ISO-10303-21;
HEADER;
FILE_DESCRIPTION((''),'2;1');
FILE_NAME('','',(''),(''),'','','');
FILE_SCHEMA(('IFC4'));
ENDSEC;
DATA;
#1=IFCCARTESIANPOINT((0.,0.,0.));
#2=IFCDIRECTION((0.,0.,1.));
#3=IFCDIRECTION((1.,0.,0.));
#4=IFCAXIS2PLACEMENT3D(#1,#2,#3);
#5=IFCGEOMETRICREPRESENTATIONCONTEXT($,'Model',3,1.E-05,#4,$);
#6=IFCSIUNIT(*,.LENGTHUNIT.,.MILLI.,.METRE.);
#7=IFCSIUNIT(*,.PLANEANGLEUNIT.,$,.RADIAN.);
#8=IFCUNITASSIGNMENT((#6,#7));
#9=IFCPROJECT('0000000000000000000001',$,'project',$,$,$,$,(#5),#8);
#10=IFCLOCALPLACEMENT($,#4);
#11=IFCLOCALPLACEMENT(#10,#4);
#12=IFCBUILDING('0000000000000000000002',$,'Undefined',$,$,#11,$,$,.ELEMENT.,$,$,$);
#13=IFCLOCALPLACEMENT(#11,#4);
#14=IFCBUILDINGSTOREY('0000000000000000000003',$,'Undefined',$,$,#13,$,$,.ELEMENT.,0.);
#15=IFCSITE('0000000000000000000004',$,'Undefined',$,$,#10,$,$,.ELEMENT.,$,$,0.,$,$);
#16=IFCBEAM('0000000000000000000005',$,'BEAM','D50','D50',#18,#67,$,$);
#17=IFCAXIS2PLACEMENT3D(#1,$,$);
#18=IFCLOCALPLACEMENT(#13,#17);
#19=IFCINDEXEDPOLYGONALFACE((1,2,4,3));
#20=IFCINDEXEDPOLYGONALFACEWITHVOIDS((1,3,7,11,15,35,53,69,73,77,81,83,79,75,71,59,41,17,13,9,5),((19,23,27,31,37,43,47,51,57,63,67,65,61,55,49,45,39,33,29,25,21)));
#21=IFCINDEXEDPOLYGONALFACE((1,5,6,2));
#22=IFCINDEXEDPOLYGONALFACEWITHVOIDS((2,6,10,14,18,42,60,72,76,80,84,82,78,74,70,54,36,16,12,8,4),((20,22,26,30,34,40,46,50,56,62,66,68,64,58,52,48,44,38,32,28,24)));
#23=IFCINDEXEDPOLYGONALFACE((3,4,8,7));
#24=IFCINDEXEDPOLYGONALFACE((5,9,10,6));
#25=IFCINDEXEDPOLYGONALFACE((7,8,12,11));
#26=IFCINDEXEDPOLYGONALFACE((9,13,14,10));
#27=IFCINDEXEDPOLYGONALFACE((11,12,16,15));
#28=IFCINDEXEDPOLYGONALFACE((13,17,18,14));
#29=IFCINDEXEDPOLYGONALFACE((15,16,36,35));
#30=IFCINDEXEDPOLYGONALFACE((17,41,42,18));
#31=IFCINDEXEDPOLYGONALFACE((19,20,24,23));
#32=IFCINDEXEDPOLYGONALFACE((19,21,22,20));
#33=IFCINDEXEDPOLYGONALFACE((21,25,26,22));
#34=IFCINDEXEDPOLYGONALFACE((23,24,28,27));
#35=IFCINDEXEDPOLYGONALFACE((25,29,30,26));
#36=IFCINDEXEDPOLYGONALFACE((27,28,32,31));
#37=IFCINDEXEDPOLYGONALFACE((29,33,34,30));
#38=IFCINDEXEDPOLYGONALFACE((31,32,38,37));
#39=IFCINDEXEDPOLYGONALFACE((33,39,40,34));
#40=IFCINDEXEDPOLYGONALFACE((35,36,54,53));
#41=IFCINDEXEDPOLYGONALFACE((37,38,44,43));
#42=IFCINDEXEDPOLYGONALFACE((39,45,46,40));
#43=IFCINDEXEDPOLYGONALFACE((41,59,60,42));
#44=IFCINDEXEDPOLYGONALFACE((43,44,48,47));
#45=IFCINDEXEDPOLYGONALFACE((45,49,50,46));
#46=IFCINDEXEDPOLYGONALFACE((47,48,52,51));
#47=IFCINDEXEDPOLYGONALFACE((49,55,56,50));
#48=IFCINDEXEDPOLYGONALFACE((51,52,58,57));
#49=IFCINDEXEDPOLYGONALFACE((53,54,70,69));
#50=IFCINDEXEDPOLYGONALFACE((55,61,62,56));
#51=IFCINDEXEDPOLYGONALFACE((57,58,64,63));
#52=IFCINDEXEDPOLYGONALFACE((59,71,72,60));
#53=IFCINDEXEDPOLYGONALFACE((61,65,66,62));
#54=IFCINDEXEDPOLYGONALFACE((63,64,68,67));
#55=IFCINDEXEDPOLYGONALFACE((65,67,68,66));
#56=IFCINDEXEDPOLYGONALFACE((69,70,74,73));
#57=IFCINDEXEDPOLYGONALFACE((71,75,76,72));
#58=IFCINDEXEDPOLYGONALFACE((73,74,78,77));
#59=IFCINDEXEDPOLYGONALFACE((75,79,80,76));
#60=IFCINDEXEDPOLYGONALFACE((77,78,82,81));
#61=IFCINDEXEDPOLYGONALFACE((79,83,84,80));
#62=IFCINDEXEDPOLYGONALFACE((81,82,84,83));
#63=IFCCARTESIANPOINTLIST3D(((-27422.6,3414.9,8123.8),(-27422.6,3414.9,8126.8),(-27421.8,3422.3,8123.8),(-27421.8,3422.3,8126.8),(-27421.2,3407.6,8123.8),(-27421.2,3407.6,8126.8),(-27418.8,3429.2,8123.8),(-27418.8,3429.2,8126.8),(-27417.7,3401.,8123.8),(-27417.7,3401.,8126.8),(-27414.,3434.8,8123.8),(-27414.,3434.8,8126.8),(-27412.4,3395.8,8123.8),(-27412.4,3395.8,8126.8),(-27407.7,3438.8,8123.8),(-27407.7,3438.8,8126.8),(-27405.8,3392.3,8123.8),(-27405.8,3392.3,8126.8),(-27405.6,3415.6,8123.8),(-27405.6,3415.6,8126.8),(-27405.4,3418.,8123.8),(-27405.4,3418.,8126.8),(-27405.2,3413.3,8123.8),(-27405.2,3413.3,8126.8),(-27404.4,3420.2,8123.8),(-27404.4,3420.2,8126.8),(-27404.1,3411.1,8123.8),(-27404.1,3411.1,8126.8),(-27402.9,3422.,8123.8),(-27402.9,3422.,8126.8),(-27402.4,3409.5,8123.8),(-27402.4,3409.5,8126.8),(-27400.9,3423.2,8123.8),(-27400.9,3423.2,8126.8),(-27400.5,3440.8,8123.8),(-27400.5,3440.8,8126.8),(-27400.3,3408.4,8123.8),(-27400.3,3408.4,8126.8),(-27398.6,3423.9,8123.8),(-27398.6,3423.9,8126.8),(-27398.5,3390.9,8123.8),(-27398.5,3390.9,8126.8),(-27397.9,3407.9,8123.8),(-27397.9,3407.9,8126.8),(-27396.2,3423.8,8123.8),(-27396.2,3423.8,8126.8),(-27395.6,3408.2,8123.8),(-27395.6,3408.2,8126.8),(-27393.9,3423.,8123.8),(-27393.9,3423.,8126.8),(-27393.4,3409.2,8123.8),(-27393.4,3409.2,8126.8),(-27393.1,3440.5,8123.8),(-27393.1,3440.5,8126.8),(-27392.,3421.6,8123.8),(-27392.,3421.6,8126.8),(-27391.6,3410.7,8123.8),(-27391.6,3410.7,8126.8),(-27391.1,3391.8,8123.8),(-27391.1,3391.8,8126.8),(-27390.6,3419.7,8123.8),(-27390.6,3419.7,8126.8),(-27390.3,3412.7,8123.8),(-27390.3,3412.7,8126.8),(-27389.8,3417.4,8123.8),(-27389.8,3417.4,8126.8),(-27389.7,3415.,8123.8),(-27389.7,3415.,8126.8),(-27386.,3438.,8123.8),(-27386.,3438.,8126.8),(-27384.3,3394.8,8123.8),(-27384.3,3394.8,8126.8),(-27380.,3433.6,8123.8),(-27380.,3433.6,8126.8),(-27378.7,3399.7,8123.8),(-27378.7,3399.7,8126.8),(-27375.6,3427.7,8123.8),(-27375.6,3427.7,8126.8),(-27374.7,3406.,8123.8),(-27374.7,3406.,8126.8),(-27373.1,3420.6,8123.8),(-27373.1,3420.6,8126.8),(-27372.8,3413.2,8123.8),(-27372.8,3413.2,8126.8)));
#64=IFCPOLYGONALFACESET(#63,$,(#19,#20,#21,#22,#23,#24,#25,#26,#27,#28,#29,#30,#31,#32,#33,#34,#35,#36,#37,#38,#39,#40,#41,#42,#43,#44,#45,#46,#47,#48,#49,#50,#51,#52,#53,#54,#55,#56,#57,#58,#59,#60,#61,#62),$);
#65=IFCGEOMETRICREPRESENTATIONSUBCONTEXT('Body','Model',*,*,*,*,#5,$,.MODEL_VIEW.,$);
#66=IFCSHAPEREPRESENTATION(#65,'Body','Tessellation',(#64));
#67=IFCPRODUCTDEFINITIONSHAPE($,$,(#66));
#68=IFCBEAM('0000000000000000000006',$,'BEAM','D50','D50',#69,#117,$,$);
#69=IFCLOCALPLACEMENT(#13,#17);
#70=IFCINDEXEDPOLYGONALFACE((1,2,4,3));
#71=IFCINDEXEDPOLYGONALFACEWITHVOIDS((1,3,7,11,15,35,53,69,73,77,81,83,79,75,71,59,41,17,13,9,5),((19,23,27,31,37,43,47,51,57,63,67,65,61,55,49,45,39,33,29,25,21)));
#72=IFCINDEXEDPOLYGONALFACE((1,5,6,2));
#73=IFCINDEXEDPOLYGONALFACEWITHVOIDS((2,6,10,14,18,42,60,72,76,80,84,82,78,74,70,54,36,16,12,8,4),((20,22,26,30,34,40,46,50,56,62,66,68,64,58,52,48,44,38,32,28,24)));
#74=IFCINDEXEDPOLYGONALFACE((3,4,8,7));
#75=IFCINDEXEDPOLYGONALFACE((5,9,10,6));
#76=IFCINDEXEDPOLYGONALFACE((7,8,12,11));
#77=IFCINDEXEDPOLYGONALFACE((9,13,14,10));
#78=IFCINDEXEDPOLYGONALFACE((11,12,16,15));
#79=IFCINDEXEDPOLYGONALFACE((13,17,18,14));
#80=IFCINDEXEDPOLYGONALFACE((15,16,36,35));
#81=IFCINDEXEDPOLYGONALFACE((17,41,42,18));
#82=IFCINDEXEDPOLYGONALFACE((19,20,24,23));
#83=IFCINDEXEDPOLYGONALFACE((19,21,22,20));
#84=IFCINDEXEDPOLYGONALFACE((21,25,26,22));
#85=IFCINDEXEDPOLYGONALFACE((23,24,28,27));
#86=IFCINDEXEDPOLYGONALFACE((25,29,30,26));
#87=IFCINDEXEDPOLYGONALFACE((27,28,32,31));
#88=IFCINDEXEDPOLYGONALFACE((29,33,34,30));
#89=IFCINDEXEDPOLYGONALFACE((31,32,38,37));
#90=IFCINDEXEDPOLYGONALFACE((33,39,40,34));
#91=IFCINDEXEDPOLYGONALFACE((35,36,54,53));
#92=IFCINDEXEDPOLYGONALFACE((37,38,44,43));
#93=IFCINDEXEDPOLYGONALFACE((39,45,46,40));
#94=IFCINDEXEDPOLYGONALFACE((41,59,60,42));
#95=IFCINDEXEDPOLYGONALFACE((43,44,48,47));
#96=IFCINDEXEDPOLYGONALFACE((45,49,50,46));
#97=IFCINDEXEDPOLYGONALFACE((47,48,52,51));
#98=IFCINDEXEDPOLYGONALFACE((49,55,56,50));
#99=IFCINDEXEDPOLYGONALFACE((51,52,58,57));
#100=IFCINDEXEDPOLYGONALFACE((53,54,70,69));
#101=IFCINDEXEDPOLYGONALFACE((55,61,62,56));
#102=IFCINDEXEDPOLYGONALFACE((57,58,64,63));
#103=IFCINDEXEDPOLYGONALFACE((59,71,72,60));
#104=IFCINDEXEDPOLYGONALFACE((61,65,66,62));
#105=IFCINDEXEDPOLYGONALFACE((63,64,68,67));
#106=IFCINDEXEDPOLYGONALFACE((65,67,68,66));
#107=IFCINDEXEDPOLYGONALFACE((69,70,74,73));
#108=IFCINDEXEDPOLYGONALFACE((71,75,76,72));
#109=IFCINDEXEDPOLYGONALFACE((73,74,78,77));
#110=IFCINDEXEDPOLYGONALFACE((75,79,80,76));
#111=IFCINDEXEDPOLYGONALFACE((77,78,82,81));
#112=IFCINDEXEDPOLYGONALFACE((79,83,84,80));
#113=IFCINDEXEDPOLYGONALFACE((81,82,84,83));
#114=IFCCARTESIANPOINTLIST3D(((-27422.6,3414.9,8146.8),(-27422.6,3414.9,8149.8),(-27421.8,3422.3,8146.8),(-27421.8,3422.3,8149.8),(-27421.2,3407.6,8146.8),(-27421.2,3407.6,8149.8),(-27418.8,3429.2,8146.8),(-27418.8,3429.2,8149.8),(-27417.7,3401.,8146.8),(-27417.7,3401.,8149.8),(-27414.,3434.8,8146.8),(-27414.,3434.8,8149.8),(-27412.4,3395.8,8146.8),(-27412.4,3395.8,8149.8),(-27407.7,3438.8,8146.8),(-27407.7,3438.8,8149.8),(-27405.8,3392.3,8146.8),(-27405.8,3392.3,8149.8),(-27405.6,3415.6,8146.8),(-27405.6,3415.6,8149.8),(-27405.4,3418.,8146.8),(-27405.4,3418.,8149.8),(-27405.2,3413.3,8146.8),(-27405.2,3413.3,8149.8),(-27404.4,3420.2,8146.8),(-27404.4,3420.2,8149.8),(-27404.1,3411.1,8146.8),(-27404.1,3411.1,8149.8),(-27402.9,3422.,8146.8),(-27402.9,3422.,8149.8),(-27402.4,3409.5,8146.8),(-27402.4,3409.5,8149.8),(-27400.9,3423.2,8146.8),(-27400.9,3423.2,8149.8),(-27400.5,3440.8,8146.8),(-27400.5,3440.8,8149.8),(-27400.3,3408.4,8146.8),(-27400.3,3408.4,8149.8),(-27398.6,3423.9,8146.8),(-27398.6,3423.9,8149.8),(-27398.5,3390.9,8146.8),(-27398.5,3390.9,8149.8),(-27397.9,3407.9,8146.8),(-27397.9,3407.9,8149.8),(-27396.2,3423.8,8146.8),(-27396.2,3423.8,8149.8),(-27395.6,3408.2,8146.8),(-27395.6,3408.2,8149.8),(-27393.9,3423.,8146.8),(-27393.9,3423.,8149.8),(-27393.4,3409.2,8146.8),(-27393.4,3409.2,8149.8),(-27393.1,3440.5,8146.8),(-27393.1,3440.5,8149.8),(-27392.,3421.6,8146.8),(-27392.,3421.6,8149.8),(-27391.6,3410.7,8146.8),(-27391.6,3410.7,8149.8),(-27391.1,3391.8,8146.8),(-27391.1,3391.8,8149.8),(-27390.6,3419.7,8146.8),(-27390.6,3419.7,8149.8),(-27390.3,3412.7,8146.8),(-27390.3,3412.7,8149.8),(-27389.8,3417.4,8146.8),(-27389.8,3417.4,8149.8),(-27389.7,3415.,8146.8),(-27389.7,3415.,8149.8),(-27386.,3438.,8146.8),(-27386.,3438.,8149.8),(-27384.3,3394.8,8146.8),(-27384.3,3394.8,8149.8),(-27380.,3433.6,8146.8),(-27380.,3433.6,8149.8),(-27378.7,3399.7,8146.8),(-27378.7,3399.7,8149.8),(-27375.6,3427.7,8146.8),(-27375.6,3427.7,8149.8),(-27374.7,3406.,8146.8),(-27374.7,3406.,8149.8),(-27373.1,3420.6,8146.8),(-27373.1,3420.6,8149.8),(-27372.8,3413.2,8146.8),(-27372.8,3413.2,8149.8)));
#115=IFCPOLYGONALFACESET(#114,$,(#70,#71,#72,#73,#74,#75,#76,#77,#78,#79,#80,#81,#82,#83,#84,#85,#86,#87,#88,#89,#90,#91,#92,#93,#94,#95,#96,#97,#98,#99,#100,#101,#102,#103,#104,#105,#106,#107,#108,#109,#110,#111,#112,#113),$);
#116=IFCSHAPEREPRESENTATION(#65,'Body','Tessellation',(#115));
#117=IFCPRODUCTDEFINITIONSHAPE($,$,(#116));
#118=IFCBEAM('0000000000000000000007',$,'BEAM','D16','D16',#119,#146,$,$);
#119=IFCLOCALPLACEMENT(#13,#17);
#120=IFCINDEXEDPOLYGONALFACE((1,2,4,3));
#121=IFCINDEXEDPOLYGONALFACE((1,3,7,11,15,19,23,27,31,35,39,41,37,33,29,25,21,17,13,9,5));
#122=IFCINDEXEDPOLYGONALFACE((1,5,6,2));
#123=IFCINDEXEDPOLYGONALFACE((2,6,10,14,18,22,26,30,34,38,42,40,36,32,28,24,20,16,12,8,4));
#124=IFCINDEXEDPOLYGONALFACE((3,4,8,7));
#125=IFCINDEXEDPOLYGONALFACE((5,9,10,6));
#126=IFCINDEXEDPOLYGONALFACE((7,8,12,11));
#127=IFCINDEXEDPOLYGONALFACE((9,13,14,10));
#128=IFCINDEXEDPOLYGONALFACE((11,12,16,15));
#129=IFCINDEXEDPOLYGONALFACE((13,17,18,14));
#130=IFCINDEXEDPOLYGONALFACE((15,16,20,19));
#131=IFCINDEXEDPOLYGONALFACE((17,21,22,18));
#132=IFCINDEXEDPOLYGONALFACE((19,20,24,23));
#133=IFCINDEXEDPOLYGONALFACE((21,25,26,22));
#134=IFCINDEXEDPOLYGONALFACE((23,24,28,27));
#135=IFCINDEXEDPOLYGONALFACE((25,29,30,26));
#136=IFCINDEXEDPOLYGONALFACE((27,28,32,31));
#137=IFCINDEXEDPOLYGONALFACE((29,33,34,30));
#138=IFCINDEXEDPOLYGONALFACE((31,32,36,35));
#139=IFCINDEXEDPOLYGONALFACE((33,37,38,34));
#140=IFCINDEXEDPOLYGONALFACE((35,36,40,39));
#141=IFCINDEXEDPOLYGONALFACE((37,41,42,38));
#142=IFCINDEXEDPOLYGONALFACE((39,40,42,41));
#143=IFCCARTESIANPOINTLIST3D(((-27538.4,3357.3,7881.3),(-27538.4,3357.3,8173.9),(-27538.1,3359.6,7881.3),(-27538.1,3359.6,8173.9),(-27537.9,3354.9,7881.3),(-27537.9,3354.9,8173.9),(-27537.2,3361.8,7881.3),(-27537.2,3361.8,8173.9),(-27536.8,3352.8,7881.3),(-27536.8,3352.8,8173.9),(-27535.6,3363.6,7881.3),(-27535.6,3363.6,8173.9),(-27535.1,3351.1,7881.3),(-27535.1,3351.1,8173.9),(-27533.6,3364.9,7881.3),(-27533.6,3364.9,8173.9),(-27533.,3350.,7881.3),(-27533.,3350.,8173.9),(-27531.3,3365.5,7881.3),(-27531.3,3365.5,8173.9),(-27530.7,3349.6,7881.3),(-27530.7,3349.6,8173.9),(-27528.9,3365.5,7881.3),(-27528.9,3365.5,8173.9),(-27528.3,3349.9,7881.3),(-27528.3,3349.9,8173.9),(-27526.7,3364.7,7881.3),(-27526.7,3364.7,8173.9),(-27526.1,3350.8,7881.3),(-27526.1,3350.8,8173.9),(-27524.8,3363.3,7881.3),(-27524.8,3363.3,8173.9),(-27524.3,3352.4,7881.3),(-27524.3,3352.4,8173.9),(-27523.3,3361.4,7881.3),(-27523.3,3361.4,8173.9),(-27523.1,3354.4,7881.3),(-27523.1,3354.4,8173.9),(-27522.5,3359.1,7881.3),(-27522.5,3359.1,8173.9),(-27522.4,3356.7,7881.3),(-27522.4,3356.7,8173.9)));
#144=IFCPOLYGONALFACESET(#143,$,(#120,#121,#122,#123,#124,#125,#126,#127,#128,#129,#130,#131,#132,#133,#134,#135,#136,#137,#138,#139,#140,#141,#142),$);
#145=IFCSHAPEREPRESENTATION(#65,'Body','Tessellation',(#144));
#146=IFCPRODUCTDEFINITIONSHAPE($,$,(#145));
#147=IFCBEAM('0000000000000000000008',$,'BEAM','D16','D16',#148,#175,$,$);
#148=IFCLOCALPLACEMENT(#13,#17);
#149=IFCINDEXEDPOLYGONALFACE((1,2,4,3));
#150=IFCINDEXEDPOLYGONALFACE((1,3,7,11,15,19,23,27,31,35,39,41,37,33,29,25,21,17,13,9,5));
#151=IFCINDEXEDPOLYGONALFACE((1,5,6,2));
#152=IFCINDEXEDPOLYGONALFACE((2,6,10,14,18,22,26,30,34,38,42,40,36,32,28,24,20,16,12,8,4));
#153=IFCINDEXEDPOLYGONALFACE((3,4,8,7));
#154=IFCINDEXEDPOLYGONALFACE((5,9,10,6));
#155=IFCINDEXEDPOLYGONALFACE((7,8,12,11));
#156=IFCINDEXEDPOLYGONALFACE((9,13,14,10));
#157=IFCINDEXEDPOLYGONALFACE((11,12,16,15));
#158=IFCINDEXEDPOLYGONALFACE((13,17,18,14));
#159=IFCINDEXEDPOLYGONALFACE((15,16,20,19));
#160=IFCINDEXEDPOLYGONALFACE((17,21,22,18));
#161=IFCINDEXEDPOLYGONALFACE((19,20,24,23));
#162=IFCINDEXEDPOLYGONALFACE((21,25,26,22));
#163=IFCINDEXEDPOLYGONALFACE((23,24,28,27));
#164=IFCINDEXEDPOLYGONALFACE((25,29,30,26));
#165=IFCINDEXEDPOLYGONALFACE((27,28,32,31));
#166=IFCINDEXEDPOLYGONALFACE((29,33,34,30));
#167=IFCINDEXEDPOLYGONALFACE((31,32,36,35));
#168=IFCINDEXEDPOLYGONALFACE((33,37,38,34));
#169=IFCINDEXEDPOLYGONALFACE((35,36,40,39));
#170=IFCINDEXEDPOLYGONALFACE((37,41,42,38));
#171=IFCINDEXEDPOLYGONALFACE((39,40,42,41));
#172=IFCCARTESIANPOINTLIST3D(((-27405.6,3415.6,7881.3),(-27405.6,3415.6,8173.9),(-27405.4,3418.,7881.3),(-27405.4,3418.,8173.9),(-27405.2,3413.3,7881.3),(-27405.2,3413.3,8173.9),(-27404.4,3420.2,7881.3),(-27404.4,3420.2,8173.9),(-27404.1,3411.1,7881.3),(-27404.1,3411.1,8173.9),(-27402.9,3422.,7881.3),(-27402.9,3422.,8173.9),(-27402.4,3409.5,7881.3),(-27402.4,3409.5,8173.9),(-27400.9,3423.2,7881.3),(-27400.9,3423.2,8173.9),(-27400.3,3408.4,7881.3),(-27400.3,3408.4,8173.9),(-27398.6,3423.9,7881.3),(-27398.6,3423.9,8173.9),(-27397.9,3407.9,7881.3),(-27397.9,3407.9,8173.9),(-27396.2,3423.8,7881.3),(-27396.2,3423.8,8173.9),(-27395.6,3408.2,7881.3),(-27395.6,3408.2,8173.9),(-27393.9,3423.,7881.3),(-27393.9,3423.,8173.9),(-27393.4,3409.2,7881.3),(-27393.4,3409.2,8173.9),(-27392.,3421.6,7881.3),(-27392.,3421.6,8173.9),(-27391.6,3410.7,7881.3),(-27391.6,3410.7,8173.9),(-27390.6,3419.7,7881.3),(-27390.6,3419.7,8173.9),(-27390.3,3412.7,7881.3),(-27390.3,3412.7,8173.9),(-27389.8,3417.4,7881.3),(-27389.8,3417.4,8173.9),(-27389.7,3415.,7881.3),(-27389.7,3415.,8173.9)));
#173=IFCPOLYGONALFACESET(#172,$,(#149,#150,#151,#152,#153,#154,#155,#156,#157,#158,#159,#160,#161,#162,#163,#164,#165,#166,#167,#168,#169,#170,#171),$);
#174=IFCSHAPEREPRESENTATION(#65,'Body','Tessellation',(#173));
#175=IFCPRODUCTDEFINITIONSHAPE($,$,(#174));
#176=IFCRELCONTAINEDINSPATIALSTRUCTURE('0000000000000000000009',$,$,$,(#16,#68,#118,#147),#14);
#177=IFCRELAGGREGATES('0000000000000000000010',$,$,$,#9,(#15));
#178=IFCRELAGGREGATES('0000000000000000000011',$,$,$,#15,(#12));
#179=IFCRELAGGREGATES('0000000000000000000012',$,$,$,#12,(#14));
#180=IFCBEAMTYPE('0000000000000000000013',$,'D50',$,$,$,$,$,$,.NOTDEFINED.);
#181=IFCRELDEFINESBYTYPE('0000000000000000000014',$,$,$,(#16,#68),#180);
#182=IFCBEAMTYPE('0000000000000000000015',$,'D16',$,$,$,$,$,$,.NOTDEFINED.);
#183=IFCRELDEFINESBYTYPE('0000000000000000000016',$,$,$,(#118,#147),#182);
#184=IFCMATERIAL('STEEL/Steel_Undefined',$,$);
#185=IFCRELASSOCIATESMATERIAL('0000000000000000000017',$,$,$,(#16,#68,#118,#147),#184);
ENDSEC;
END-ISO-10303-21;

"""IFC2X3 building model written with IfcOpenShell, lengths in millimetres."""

from ifc_helpers import new_model, si_unit, frame, origin_with_axes, origin_2d_with_axis, place, context, subcontext, project, spatial, circle, extrude, material, type_object, element, save


model = new_model("IFC2X3")

# Units and contexts
model_context = context("Model", 3, precision=1e-05, world=origin_with_axes())
body_context = subcontext(model_context, "Body", "Model", "MODEL_VIEW")
ifc_project = project(units=[si_unit("LENGTHUNIT", "METRE", prefix="MILLI"), si_unit("PLANEANGLEUNIT", "RADIAN")], contexts=[model_context])

# Site, building, storey
site_placement = place(None, origin_with_axes())
site = spatial("IfcSite", under=ifc_project, at=site_placement, Name="Undefined", CompositionType="ELEMENT", RefElevation=0.0)
building_placement = place(site_placement, origin_with_axes())
building = spatial("IfcBuilding", under=site, at=building_placement, Name="Undefined", CompositionType="ELEMENT")
storey_placement = place(building_placement, origin_with_axes())
storey = spatial("IfcBuildingStorey", under=building, at=storey_placement, Name="Undefined", CompositionType="ELEMENT", Elevation=0.0)

# Shared definitions
ifc_material = material(Name="STEEL/Steel_Undefined")

# Beams, openings
beam_type_1 = type_object("IfcBeamType", Name="D50", PredefinedType="NOTDEFINED")
beam_1_placement = place(storey_placement, frame((-27397.6, 3415.9, 8126.8), z_axis=(-0.915553, -0.402198, 0.0), x_axis=(0.0, 0.0, -1.0)))
beam_1 = element("IfcBeam", 1, at=beam_1_placement, inside=storey, type_object=beam_type_1, material=ifc_material, Name="BEAM", Description="D50", ObjectType="D50", context=body_context, shape_type="SweptSolid", body=[
    extrude(circle(Radius=25.0, at=origin_2d_with_axis()), frame((3.0, 0.0, 0.0), z_axis=(-1.0, 0.0, 0.0), x_axis=(0.0, -1.0, 0.0)), (0.0, 0.0, 1.0), 3.0),
])
opening_1_placement = place(storey_placement, frame((-27397.6, 3415.9, 8126.8), z_axis=(-0.915553, -0.402198, 0.0), x_axis=(0.0, 0.0, -1.0)))
element("IfcOpeningElement", 2, at=opening_1_placement, cuts=beam_1, ObjectType="Recess", context=body_context, shape_type="SweptSolid", body=[
    extrude(circle(Radius=8.0, at=origin_2d_with_axis()), frame((245.5, 0.0, 0.0), z_axis=(-1.0, 0.0, 0.0), x_axis=(0.0, -1.0, 0.0)), (0.0, 0.0, 1.0), 292.6),
])
beam_2_placement = place(storey_placement, frame((-27397.6, 3415.9, 8149.8), z_axis=(-0.915553, -0.402198, 0.0), x_axis=(0.0, 0.0, -1.0)))
beam_2 = element("IfcBeam", 3, at=beam_2_placement, inside=storey, type_object=beam_type_1, material=ifc_material, Name="BEAM", Description="D50", ObjectType="D50", context=body_context, shape_type="SweptSolid", body=[
    extrude(circle(Radius=25.0, at=origin_2d_with_axis()), frame((3.0, 0.0, 0.0), z_axis=(-1.0, 0.0, 0.0), x_axis=(0.0, -1.0, 0.0)), (0.0, 0.0, 1.0), 3.0),
])
opening_2_placement = place(storey_placement, frame((-27397.6, 3415.9, 8149.8), z_axis=(-0.915553, -0.402198, 0.0), x_axis=(0.0, 0.0, -1.0)))
element("IfcOpeningElement", 4, at=opening_2_placement, cuts=beam_2, ObjectType="Recess", context=body_context, shape_type="SweptSolid", body=[
    extrude(circle(Radius=8.0, at=origin_2d_with_axis()), frame((268.5, 0.0, 0.0), z_axis=(-1.0, 0.0, 0.0), x_axis=(0.0, -1.0, 0.0)), (0.0, 0.0, 1.0), 292.6),
])

# Beams
beam_type_2 = type_object("IfcBeamType", Name="D16", PredefinedType="NOTDEFINED")
for number, where, z_axis, x_axis, name in (
    (5, (-27530.4, 3357.6, 8173.9), (-0.915553, -0.402198, 0.0), (0.0, 0.0, -1.0), "BEAM"),
    (6, (-27397.6, 3415.9, 8173.9), (-0.915553, -0.402198, 0.0), (0.0, 0.0, -1.0), "BEAM"),
):
    element("IfcBeam", number, at=place(storey_placement, frame(where, z_axis=z_axis, x_axis=x_axis)), inside=storey, type_object=beam_type_2, material=ifc_material, Name=name, Description="D16", ObjectType="D16", context=body_context, shape_type="SweptSolid", body=[
        extrude(circle(Radius=8.0, at=origin_2d_with_axis()), frame((292.6, 0.0, 0.0), z_axis=(-1.0, 0.0, 0.0), x_axis=(0.0, -1.0, 0.0)), (0.0, 0.0, 1.0), 292.6),
    ])

save(model, "model.ifc")
